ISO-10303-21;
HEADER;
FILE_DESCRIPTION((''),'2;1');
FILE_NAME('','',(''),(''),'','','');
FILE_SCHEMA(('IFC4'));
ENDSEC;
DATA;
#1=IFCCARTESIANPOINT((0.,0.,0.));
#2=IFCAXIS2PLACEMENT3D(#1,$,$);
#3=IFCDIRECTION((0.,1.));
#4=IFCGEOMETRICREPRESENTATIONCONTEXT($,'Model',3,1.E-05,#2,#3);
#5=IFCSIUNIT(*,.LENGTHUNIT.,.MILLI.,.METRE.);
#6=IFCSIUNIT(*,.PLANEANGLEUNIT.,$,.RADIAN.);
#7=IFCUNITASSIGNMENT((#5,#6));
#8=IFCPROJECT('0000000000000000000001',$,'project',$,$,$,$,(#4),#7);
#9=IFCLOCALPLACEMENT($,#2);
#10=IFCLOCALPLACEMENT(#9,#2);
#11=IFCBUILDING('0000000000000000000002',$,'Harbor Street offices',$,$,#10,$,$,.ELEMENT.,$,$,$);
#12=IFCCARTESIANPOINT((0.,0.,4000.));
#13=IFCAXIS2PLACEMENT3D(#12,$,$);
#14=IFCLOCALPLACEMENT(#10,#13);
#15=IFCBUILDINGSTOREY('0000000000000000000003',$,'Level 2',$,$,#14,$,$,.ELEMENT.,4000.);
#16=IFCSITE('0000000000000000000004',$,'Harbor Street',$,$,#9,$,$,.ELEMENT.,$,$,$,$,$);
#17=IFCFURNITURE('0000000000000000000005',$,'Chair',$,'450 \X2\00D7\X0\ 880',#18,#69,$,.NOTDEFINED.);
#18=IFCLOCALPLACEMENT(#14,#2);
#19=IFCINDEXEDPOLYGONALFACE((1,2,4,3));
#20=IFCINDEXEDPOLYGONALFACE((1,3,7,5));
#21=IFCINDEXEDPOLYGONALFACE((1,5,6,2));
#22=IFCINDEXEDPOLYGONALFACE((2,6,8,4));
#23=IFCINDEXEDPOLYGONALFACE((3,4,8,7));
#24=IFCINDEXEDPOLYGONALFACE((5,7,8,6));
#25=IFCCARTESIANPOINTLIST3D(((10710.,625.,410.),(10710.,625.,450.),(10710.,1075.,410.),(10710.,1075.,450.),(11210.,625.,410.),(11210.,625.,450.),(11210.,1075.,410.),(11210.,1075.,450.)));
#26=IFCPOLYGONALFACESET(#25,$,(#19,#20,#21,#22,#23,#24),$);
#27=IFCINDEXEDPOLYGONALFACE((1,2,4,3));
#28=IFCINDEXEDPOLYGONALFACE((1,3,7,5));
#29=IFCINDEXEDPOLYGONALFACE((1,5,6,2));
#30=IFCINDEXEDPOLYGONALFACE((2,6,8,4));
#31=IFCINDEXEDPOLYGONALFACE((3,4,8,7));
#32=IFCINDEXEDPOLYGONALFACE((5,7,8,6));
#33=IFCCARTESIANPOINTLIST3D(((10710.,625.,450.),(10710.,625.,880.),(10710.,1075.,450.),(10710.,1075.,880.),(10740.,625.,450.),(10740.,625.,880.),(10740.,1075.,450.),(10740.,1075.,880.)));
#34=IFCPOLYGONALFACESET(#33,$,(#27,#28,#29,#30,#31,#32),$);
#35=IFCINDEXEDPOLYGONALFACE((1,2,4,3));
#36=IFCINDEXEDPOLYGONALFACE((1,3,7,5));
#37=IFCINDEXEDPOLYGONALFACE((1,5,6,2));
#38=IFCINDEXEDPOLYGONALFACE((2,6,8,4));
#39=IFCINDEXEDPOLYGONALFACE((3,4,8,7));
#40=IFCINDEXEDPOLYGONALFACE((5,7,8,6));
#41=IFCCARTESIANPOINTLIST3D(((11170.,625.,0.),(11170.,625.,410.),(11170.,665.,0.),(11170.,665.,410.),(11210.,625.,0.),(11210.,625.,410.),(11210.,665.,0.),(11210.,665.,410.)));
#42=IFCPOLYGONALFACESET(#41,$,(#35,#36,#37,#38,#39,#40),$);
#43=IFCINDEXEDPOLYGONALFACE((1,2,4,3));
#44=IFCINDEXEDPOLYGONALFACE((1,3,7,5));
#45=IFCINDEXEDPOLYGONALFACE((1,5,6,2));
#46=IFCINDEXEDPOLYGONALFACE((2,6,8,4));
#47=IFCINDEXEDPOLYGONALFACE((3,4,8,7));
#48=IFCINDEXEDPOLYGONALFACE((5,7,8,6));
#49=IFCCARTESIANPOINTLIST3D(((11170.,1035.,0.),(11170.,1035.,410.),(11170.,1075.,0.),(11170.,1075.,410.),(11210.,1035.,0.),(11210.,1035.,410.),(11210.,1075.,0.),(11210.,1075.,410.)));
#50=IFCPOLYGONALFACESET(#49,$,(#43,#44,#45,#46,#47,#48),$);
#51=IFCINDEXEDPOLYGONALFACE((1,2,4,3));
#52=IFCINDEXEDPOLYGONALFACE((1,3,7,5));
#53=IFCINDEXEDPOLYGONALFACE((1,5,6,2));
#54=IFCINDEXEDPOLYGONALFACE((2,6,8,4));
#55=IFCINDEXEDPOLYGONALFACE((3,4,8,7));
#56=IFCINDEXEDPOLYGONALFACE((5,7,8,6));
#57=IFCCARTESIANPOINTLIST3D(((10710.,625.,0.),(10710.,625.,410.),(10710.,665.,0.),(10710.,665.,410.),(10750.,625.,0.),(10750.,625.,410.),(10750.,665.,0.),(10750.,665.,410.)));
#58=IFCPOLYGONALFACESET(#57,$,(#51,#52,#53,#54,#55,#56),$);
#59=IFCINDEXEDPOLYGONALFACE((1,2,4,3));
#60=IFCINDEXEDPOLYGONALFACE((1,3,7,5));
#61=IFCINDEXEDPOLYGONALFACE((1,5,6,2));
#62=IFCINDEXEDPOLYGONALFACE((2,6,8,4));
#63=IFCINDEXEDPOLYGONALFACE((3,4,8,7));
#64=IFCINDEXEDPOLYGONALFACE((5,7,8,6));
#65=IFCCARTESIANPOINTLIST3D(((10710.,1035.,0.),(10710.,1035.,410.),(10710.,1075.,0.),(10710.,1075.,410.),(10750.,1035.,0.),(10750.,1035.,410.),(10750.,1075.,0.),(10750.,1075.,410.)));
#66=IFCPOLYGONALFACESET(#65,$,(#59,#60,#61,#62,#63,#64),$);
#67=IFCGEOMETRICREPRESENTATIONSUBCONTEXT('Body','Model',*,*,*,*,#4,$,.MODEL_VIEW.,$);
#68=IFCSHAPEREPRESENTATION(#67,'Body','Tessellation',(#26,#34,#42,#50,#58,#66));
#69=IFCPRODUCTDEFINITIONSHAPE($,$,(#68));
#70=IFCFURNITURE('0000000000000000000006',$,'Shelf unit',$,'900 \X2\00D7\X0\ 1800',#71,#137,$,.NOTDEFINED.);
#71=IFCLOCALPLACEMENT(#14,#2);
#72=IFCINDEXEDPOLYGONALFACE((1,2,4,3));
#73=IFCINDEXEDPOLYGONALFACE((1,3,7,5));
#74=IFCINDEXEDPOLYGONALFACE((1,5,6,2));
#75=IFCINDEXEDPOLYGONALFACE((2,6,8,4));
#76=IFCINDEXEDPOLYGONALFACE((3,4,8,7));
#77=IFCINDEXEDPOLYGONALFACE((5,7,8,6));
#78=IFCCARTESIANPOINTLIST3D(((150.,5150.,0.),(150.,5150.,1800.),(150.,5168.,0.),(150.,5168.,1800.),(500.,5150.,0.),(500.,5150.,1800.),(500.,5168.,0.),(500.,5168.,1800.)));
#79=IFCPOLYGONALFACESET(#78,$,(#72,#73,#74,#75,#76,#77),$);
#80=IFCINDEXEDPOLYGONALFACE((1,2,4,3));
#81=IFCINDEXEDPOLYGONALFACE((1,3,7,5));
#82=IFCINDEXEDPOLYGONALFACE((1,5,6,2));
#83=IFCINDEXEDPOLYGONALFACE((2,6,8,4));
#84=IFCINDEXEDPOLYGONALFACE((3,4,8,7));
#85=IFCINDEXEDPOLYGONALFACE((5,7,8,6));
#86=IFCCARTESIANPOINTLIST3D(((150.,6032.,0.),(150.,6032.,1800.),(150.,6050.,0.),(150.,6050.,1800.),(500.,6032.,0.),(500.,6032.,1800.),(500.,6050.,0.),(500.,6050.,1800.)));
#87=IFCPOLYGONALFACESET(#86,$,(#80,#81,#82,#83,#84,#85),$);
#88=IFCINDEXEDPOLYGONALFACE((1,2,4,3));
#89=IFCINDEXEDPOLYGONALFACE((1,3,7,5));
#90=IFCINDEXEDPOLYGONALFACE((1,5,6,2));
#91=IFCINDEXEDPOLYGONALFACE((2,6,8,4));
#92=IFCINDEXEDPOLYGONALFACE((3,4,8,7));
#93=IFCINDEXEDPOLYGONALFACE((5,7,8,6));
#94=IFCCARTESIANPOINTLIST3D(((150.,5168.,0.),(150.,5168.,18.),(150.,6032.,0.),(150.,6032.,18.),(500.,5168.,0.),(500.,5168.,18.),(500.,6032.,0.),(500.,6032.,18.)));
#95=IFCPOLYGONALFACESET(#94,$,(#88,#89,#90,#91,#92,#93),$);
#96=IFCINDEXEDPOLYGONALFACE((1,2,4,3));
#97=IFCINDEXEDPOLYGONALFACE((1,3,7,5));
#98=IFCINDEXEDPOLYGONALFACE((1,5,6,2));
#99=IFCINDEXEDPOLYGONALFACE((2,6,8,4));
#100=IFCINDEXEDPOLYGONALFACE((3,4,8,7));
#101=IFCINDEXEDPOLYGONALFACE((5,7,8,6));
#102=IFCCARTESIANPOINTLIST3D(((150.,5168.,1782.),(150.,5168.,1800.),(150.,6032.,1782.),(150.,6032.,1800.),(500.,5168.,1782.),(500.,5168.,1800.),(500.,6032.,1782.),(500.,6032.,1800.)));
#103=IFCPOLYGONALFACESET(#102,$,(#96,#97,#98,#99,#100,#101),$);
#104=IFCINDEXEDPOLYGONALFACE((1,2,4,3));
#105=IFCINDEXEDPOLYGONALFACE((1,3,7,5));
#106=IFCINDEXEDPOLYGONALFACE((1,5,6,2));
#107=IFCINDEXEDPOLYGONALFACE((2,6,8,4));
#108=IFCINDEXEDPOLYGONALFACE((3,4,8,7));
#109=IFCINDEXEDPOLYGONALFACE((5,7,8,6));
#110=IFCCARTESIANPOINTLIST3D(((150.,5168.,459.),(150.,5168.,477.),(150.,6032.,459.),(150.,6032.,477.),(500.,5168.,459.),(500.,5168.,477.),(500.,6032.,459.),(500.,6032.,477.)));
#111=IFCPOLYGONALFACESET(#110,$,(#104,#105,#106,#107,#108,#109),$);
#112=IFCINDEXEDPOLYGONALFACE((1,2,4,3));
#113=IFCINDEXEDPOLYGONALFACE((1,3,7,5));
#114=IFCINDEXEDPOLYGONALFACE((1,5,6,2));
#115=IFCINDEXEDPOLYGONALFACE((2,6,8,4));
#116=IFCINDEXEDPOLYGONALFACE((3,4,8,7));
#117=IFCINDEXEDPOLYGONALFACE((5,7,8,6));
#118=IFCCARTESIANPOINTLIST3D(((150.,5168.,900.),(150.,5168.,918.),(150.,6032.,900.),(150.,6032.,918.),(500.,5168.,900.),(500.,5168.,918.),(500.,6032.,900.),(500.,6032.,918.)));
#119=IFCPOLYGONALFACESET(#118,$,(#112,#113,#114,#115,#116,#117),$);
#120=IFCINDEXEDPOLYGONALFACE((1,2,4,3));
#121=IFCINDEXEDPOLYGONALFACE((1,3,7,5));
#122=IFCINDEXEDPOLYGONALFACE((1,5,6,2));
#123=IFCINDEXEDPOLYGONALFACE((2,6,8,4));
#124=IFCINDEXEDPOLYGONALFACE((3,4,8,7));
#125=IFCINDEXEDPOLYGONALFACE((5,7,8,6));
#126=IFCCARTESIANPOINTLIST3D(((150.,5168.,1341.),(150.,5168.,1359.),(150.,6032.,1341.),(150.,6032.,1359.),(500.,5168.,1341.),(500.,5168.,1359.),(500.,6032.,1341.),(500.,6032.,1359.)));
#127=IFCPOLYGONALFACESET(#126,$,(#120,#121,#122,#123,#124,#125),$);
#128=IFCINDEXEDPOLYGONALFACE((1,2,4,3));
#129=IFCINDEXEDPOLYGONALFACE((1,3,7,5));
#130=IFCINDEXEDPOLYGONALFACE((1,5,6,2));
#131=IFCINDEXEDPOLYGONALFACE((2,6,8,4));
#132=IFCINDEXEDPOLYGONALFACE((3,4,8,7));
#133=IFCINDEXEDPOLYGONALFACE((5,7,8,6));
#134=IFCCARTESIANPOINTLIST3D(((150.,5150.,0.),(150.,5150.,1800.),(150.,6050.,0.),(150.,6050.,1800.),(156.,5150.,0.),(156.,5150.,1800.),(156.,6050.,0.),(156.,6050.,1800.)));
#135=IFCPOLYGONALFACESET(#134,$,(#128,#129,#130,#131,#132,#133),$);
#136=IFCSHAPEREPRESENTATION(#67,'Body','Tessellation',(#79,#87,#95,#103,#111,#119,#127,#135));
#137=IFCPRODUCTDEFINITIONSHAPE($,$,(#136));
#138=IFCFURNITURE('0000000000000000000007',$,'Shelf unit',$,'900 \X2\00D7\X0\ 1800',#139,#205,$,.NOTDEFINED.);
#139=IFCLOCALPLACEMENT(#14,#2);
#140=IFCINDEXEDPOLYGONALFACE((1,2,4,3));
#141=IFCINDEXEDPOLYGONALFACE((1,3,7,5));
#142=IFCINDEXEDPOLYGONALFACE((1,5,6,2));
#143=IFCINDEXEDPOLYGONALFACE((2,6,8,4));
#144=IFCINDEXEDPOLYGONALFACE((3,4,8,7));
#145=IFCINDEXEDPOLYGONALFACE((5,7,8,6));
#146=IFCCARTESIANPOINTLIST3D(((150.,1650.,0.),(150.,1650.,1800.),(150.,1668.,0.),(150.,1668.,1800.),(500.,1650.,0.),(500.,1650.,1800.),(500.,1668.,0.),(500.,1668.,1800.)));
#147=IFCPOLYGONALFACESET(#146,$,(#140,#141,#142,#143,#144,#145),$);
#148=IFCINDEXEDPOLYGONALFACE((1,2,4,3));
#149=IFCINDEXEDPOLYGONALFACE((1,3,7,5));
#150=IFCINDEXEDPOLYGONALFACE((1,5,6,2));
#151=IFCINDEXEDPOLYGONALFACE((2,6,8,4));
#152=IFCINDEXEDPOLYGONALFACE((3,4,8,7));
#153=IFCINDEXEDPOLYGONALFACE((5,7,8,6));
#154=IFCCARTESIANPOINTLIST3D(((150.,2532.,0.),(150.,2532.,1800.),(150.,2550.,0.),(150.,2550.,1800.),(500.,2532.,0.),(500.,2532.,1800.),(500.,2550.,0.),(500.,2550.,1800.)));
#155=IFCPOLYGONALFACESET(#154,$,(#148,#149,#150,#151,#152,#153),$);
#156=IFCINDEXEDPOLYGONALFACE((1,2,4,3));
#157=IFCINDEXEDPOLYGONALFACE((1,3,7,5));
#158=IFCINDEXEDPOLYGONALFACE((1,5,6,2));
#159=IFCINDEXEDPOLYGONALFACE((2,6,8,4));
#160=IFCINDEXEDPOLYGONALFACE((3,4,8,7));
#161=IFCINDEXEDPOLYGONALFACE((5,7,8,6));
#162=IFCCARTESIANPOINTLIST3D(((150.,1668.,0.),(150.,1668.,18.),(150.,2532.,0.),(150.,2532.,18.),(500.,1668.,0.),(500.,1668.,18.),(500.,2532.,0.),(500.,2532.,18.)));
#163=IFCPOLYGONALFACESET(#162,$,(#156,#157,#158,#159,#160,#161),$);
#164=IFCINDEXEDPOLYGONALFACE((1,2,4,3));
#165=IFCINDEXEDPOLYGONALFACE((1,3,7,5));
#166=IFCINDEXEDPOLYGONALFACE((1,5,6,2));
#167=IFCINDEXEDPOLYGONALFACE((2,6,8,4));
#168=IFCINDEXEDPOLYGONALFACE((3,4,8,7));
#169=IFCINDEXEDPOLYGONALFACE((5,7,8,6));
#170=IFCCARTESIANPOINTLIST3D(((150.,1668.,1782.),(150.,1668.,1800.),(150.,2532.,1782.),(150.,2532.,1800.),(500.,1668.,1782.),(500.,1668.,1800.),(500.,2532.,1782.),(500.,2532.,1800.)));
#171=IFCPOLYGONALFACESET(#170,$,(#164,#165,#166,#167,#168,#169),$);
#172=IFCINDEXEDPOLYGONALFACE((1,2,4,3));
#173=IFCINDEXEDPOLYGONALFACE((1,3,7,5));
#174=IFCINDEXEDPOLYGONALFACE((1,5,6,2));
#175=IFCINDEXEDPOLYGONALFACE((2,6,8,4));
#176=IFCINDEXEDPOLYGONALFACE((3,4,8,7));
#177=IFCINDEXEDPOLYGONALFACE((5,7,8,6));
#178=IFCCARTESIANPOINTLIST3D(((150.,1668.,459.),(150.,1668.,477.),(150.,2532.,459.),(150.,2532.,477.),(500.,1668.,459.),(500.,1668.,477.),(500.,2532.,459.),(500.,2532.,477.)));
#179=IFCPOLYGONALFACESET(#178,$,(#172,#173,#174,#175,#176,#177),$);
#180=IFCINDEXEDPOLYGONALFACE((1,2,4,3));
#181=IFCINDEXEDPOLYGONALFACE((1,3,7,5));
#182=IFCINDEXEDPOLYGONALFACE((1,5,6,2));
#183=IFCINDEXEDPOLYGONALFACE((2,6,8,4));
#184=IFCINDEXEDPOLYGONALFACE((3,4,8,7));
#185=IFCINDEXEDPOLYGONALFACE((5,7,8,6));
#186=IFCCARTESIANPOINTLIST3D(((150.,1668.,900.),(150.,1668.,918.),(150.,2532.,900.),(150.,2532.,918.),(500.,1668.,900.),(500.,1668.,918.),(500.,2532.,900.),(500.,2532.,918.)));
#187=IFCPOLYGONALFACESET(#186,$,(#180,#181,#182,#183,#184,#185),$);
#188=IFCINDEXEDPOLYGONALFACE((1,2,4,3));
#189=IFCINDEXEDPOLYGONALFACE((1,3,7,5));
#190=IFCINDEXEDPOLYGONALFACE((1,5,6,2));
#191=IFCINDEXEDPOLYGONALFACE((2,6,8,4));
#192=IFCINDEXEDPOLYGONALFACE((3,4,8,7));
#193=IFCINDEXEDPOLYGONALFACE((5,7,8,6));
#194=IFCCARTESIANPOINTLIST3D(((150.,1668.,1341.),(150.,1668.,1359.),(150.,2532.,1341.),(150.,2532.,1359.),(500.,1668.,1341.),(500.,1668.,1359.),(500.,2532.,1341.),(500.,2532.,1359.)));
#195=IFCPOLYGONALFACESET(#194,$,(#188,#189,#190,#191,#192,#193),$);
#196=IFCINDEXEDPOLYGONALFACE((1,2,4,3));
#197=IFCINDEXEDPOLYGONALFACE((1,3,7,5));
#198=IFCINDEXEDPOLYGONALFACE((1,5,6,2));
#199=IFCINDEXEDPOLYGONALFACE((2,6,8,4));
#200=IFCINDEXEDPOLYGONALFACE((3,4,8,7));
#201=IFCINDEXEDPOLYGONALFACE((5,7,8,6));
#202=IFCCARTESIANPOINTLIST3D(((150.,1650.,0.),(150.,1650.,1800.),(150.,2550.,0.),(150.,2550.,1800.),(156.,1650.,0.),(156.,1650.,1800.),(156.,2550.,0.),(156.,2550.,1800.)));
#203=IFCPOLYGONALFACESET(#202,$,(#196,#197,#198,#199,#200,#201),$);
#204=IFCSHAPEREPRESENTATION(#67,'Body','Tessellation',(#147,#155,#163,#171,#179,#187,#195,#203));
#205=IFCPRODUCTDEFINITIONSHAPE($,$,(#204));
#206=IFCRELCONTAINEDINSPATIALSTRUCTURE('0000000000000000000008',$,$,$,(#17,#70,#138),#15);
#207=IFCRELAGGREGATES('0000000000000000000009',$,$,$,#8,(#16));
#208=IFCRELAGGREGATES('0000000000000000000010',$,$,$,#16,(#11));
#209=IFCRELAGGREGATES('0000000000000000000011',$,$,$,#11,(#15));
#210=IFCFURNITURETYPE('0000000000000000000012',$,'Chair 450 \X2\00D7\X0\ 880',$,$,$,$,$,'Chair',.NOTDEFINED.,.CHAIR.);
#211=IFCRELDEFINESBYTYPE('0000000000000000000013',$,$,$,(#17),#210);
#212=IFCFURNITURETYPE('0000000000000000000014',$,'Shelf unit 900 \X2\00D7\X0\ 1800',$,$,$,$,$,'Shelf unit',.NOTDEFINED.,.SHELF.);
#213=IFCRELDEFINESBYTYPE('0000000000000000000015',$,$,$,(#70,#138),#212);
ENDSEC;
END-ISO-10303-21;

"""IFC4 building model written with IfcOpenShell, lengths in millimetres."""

from ifc_helpers import new_model, si_unit, direction, frame, origin, place, context, subcontext, project, spatial, polyline, outline, extrude, source, transform, mapped, type_object, type_shapes, element, save


model = new_model("IFC4")

# Units and contexts
model_context = context("Model", 3, precision=1e-05, world=origin(), true_north=direction((0.0, 1.0)))
body_context = subcontext(model_context, "Body", "Model", "MODEL_VIEW")
ifc_project = project(units=[si_unit("LENGTHUNIT", "METRE", prefix="MILLI"), si_unit("PLANEANGLEUNIT", "RADIAN")], contexts=[model_context])

# Site, building, storey
site_placement = place(None, origin())
site = spatial("IfcSite", under=ifc_project, at=site_placement, Name="Harbor Street", CompositionType="ELEMENT")
building_placement = place(site_placement, origin())
building = spatial("IfcBuilding", under=site, at=building_placement, Name="Harbor Street offices", CompositionType="ELEMENT")
storey_placement = place(building_placement, frame((0.0, 0.0, 4000.0)))
storey = spatial("IfcBuildingStorey", under=building, at=storey_placement, Name="Level 2", CompositionType="ELEMENT", Elevation=4000.0)

# Furniture
furniture_type_1 = type_object("IfcFurnitureType", Name="Chair 450 × 880", ElementType="Chair", AssemblyPlace="NOTDEFINED", PredefinedType="CHAIR")
shared_shape_1 = source(origin(), body_context, "Body", "SweptSolid", [
    extrude(outline(polyline([(-225.0, 0.0), (225.0, 0.0), (225.0, 500.0), (-225.0, 500.0), (-225.0, 0.0)])), frame((0.0, 0.0, 410.0)), (0.0, 0.0, 1.0), 40.0),
    extrude(outline(polyline([(-225.0, 470.0), (225.0, 470.0), (225.0, 500.0), (-225.0, 500.0), (-225.0, 470.0)])), frame((0.0, 0.0, 450.0)), (0.0, 0.0, 1.0), 430.0),
    extrude(outline(polyline([(-225.0, 0.0), (-185.0, 0.0), (-185.0, 40.0), (-225.0, 40.0), (-225.0, 0.0)])), origin(), (0.0, 0.0, 1.0), 410.0),
    extrude(outline(polyline([(185.0, 0.0), (225.0, 0.0), (225.0, 40.0), (185.0, 40.0), (185.0, 0.0)])), origin(), (0.0, 0.0, 1.0), 410.0),
    extrude(outline(polyline([(-225.0, 460.0), (-185.0, 460.0), (-185.0, 500.0), (-225.0, 500.0), (-225.0, 460.0)])), origin(), (0.0, 0.0, 1.0), 410.0),
    extrude(outline(polyline([(185.0, 460.0), (225.0, 460.0), (225.0, 500.0), (185.0, 500.0), (185.0, 460.0)])), origin(), (0.0, 0.0, 1.0), 410.0),
])
type_shapes(furniture_type_1, [shared_shape_1])
for number, where, z_axis, x_axis, name in (
    (1, (11210.0, 850.0, 0.0), (0.0, 0.0, 1.0), (0.0, 1.0, 0.0), "Chair"),
):
    element("IfcFurniture", number, at=place(storey_placement, frame(where, z_axis=z_axis, x_axis=x_axis)), inside=storey, type_object=furniture_type_1, Name=name, ObjectType="450 × 880", PredefinedType="NOTDEFINED", context=body_context, shape_type="MappedRepresentation", body=[
        mapped(shared_shape_1, transform((0.0, 0.0, 0.0))),
    ])
furniture_type_2 = type_object("IfcFurnitureType", Name="Shelf unit 900 × 1800", ElementType="Shelf unit", AssemblyPlace="NOTDEFINED", PredefinedType="SHELF")
shared_shape_2 = source(origin(), body_context, "Body", "SweptSolid", [
    extrude(outline(polyline([(-450.0, 0.0), (-432.0, 0.0), (-432.0, 350.0), (-450.0, 350.0), (-450.0, 0.0)])), origin(), (0.0, 0.0, 1.0), 1800.0),
    extrude(outline(polyline([(432.0, 0.0), (450.0, 0.0), (450.0, 350.0), (432.0, 350.0), (432.0, 0.0)])), origin(), (0.0, 0.0, 1.0), 1800.0),
    extrude(outline(polyline([(-432.0, 0.0), (432.0, 0.0), (432.0, 350.0), (-432.0, 350.0), (-432.0, 0.0)])), origin(), (0.0, 0.0, 1.0), 18.0),
    extrude(outline(polyline([(-432.0, 0.0), (432.0, 0.0), (432.0, 350.0), (-432.0, 350.0), (-432.0, 0.0)])), frame((0.0, 0.0, 1782.0)), (0.0, 0.0, 1.0), 18.0),
    extrude(outline(polyline([(-432.0, 0.0), (432.0, 0.0), (432.0, 350.0), (-432.0, 350.0), (-432.0, 0.0)])), frame((0.0, 0.0, 459.0)), (0.0, 0.0, 1.0), 18.0),
    extrude(outline(polyline([(-432.0, 0.0), (432.0, 0.0), (432.0, 350.0), (-432.0, 350.0), (-432.0, 0.0)])), frame((0.0, 0.0, 900.0)), (0.0, 0.0, 1.0), 18.0),
    extrude(outline(polyline([(-432.0, 0.0), (432.0, 0.0), (432.0, 350.0), (-432.0, 350.0), (-432.0, 0.0)])), frame((0.0, 0.0, 1341.0)), (0.0, 0.0, 1.0), 18.0),
    extrude(outline(polyline([(-450.0, 344.0), (450.0, 344.0), (450.0, 350.0), (-450.0, 350.0), (-450.0, 344.0)])), origin(), (0.0, 0.0, 1.0), 1800.0),
])
type_shapes(furniture_type_2, [shared_shape_2])
for number, where, z_axis, x_axis, name in (
    (2, (500.0, 5600.0, 0.0), (0.0, 0.0, 1.0), (0.0, 1.0, 0.0), "Shelf unit"),
    (3, (500.0, 2100.0, 0.0), (0.0, 0.0, 1.0), (0.0, 1.0, 0.0), "Shelf unit"),
):
    element("IfcFurniture", number, at=place(storey_placement, frame(where, z_axis=z_axis, x_axis=x_axis)), inside=storey, type_object=furniture_type_2, Name=name, ObjectType="900 × 1800", PredefinedType="NOTDEFINED", context=body_context, shape_type="MappedRepresentation", body=[
        mapped(shared_shape_2, transform((0.0, 0.0, 0.0))),
    ])

save(model, "model.ifc")
